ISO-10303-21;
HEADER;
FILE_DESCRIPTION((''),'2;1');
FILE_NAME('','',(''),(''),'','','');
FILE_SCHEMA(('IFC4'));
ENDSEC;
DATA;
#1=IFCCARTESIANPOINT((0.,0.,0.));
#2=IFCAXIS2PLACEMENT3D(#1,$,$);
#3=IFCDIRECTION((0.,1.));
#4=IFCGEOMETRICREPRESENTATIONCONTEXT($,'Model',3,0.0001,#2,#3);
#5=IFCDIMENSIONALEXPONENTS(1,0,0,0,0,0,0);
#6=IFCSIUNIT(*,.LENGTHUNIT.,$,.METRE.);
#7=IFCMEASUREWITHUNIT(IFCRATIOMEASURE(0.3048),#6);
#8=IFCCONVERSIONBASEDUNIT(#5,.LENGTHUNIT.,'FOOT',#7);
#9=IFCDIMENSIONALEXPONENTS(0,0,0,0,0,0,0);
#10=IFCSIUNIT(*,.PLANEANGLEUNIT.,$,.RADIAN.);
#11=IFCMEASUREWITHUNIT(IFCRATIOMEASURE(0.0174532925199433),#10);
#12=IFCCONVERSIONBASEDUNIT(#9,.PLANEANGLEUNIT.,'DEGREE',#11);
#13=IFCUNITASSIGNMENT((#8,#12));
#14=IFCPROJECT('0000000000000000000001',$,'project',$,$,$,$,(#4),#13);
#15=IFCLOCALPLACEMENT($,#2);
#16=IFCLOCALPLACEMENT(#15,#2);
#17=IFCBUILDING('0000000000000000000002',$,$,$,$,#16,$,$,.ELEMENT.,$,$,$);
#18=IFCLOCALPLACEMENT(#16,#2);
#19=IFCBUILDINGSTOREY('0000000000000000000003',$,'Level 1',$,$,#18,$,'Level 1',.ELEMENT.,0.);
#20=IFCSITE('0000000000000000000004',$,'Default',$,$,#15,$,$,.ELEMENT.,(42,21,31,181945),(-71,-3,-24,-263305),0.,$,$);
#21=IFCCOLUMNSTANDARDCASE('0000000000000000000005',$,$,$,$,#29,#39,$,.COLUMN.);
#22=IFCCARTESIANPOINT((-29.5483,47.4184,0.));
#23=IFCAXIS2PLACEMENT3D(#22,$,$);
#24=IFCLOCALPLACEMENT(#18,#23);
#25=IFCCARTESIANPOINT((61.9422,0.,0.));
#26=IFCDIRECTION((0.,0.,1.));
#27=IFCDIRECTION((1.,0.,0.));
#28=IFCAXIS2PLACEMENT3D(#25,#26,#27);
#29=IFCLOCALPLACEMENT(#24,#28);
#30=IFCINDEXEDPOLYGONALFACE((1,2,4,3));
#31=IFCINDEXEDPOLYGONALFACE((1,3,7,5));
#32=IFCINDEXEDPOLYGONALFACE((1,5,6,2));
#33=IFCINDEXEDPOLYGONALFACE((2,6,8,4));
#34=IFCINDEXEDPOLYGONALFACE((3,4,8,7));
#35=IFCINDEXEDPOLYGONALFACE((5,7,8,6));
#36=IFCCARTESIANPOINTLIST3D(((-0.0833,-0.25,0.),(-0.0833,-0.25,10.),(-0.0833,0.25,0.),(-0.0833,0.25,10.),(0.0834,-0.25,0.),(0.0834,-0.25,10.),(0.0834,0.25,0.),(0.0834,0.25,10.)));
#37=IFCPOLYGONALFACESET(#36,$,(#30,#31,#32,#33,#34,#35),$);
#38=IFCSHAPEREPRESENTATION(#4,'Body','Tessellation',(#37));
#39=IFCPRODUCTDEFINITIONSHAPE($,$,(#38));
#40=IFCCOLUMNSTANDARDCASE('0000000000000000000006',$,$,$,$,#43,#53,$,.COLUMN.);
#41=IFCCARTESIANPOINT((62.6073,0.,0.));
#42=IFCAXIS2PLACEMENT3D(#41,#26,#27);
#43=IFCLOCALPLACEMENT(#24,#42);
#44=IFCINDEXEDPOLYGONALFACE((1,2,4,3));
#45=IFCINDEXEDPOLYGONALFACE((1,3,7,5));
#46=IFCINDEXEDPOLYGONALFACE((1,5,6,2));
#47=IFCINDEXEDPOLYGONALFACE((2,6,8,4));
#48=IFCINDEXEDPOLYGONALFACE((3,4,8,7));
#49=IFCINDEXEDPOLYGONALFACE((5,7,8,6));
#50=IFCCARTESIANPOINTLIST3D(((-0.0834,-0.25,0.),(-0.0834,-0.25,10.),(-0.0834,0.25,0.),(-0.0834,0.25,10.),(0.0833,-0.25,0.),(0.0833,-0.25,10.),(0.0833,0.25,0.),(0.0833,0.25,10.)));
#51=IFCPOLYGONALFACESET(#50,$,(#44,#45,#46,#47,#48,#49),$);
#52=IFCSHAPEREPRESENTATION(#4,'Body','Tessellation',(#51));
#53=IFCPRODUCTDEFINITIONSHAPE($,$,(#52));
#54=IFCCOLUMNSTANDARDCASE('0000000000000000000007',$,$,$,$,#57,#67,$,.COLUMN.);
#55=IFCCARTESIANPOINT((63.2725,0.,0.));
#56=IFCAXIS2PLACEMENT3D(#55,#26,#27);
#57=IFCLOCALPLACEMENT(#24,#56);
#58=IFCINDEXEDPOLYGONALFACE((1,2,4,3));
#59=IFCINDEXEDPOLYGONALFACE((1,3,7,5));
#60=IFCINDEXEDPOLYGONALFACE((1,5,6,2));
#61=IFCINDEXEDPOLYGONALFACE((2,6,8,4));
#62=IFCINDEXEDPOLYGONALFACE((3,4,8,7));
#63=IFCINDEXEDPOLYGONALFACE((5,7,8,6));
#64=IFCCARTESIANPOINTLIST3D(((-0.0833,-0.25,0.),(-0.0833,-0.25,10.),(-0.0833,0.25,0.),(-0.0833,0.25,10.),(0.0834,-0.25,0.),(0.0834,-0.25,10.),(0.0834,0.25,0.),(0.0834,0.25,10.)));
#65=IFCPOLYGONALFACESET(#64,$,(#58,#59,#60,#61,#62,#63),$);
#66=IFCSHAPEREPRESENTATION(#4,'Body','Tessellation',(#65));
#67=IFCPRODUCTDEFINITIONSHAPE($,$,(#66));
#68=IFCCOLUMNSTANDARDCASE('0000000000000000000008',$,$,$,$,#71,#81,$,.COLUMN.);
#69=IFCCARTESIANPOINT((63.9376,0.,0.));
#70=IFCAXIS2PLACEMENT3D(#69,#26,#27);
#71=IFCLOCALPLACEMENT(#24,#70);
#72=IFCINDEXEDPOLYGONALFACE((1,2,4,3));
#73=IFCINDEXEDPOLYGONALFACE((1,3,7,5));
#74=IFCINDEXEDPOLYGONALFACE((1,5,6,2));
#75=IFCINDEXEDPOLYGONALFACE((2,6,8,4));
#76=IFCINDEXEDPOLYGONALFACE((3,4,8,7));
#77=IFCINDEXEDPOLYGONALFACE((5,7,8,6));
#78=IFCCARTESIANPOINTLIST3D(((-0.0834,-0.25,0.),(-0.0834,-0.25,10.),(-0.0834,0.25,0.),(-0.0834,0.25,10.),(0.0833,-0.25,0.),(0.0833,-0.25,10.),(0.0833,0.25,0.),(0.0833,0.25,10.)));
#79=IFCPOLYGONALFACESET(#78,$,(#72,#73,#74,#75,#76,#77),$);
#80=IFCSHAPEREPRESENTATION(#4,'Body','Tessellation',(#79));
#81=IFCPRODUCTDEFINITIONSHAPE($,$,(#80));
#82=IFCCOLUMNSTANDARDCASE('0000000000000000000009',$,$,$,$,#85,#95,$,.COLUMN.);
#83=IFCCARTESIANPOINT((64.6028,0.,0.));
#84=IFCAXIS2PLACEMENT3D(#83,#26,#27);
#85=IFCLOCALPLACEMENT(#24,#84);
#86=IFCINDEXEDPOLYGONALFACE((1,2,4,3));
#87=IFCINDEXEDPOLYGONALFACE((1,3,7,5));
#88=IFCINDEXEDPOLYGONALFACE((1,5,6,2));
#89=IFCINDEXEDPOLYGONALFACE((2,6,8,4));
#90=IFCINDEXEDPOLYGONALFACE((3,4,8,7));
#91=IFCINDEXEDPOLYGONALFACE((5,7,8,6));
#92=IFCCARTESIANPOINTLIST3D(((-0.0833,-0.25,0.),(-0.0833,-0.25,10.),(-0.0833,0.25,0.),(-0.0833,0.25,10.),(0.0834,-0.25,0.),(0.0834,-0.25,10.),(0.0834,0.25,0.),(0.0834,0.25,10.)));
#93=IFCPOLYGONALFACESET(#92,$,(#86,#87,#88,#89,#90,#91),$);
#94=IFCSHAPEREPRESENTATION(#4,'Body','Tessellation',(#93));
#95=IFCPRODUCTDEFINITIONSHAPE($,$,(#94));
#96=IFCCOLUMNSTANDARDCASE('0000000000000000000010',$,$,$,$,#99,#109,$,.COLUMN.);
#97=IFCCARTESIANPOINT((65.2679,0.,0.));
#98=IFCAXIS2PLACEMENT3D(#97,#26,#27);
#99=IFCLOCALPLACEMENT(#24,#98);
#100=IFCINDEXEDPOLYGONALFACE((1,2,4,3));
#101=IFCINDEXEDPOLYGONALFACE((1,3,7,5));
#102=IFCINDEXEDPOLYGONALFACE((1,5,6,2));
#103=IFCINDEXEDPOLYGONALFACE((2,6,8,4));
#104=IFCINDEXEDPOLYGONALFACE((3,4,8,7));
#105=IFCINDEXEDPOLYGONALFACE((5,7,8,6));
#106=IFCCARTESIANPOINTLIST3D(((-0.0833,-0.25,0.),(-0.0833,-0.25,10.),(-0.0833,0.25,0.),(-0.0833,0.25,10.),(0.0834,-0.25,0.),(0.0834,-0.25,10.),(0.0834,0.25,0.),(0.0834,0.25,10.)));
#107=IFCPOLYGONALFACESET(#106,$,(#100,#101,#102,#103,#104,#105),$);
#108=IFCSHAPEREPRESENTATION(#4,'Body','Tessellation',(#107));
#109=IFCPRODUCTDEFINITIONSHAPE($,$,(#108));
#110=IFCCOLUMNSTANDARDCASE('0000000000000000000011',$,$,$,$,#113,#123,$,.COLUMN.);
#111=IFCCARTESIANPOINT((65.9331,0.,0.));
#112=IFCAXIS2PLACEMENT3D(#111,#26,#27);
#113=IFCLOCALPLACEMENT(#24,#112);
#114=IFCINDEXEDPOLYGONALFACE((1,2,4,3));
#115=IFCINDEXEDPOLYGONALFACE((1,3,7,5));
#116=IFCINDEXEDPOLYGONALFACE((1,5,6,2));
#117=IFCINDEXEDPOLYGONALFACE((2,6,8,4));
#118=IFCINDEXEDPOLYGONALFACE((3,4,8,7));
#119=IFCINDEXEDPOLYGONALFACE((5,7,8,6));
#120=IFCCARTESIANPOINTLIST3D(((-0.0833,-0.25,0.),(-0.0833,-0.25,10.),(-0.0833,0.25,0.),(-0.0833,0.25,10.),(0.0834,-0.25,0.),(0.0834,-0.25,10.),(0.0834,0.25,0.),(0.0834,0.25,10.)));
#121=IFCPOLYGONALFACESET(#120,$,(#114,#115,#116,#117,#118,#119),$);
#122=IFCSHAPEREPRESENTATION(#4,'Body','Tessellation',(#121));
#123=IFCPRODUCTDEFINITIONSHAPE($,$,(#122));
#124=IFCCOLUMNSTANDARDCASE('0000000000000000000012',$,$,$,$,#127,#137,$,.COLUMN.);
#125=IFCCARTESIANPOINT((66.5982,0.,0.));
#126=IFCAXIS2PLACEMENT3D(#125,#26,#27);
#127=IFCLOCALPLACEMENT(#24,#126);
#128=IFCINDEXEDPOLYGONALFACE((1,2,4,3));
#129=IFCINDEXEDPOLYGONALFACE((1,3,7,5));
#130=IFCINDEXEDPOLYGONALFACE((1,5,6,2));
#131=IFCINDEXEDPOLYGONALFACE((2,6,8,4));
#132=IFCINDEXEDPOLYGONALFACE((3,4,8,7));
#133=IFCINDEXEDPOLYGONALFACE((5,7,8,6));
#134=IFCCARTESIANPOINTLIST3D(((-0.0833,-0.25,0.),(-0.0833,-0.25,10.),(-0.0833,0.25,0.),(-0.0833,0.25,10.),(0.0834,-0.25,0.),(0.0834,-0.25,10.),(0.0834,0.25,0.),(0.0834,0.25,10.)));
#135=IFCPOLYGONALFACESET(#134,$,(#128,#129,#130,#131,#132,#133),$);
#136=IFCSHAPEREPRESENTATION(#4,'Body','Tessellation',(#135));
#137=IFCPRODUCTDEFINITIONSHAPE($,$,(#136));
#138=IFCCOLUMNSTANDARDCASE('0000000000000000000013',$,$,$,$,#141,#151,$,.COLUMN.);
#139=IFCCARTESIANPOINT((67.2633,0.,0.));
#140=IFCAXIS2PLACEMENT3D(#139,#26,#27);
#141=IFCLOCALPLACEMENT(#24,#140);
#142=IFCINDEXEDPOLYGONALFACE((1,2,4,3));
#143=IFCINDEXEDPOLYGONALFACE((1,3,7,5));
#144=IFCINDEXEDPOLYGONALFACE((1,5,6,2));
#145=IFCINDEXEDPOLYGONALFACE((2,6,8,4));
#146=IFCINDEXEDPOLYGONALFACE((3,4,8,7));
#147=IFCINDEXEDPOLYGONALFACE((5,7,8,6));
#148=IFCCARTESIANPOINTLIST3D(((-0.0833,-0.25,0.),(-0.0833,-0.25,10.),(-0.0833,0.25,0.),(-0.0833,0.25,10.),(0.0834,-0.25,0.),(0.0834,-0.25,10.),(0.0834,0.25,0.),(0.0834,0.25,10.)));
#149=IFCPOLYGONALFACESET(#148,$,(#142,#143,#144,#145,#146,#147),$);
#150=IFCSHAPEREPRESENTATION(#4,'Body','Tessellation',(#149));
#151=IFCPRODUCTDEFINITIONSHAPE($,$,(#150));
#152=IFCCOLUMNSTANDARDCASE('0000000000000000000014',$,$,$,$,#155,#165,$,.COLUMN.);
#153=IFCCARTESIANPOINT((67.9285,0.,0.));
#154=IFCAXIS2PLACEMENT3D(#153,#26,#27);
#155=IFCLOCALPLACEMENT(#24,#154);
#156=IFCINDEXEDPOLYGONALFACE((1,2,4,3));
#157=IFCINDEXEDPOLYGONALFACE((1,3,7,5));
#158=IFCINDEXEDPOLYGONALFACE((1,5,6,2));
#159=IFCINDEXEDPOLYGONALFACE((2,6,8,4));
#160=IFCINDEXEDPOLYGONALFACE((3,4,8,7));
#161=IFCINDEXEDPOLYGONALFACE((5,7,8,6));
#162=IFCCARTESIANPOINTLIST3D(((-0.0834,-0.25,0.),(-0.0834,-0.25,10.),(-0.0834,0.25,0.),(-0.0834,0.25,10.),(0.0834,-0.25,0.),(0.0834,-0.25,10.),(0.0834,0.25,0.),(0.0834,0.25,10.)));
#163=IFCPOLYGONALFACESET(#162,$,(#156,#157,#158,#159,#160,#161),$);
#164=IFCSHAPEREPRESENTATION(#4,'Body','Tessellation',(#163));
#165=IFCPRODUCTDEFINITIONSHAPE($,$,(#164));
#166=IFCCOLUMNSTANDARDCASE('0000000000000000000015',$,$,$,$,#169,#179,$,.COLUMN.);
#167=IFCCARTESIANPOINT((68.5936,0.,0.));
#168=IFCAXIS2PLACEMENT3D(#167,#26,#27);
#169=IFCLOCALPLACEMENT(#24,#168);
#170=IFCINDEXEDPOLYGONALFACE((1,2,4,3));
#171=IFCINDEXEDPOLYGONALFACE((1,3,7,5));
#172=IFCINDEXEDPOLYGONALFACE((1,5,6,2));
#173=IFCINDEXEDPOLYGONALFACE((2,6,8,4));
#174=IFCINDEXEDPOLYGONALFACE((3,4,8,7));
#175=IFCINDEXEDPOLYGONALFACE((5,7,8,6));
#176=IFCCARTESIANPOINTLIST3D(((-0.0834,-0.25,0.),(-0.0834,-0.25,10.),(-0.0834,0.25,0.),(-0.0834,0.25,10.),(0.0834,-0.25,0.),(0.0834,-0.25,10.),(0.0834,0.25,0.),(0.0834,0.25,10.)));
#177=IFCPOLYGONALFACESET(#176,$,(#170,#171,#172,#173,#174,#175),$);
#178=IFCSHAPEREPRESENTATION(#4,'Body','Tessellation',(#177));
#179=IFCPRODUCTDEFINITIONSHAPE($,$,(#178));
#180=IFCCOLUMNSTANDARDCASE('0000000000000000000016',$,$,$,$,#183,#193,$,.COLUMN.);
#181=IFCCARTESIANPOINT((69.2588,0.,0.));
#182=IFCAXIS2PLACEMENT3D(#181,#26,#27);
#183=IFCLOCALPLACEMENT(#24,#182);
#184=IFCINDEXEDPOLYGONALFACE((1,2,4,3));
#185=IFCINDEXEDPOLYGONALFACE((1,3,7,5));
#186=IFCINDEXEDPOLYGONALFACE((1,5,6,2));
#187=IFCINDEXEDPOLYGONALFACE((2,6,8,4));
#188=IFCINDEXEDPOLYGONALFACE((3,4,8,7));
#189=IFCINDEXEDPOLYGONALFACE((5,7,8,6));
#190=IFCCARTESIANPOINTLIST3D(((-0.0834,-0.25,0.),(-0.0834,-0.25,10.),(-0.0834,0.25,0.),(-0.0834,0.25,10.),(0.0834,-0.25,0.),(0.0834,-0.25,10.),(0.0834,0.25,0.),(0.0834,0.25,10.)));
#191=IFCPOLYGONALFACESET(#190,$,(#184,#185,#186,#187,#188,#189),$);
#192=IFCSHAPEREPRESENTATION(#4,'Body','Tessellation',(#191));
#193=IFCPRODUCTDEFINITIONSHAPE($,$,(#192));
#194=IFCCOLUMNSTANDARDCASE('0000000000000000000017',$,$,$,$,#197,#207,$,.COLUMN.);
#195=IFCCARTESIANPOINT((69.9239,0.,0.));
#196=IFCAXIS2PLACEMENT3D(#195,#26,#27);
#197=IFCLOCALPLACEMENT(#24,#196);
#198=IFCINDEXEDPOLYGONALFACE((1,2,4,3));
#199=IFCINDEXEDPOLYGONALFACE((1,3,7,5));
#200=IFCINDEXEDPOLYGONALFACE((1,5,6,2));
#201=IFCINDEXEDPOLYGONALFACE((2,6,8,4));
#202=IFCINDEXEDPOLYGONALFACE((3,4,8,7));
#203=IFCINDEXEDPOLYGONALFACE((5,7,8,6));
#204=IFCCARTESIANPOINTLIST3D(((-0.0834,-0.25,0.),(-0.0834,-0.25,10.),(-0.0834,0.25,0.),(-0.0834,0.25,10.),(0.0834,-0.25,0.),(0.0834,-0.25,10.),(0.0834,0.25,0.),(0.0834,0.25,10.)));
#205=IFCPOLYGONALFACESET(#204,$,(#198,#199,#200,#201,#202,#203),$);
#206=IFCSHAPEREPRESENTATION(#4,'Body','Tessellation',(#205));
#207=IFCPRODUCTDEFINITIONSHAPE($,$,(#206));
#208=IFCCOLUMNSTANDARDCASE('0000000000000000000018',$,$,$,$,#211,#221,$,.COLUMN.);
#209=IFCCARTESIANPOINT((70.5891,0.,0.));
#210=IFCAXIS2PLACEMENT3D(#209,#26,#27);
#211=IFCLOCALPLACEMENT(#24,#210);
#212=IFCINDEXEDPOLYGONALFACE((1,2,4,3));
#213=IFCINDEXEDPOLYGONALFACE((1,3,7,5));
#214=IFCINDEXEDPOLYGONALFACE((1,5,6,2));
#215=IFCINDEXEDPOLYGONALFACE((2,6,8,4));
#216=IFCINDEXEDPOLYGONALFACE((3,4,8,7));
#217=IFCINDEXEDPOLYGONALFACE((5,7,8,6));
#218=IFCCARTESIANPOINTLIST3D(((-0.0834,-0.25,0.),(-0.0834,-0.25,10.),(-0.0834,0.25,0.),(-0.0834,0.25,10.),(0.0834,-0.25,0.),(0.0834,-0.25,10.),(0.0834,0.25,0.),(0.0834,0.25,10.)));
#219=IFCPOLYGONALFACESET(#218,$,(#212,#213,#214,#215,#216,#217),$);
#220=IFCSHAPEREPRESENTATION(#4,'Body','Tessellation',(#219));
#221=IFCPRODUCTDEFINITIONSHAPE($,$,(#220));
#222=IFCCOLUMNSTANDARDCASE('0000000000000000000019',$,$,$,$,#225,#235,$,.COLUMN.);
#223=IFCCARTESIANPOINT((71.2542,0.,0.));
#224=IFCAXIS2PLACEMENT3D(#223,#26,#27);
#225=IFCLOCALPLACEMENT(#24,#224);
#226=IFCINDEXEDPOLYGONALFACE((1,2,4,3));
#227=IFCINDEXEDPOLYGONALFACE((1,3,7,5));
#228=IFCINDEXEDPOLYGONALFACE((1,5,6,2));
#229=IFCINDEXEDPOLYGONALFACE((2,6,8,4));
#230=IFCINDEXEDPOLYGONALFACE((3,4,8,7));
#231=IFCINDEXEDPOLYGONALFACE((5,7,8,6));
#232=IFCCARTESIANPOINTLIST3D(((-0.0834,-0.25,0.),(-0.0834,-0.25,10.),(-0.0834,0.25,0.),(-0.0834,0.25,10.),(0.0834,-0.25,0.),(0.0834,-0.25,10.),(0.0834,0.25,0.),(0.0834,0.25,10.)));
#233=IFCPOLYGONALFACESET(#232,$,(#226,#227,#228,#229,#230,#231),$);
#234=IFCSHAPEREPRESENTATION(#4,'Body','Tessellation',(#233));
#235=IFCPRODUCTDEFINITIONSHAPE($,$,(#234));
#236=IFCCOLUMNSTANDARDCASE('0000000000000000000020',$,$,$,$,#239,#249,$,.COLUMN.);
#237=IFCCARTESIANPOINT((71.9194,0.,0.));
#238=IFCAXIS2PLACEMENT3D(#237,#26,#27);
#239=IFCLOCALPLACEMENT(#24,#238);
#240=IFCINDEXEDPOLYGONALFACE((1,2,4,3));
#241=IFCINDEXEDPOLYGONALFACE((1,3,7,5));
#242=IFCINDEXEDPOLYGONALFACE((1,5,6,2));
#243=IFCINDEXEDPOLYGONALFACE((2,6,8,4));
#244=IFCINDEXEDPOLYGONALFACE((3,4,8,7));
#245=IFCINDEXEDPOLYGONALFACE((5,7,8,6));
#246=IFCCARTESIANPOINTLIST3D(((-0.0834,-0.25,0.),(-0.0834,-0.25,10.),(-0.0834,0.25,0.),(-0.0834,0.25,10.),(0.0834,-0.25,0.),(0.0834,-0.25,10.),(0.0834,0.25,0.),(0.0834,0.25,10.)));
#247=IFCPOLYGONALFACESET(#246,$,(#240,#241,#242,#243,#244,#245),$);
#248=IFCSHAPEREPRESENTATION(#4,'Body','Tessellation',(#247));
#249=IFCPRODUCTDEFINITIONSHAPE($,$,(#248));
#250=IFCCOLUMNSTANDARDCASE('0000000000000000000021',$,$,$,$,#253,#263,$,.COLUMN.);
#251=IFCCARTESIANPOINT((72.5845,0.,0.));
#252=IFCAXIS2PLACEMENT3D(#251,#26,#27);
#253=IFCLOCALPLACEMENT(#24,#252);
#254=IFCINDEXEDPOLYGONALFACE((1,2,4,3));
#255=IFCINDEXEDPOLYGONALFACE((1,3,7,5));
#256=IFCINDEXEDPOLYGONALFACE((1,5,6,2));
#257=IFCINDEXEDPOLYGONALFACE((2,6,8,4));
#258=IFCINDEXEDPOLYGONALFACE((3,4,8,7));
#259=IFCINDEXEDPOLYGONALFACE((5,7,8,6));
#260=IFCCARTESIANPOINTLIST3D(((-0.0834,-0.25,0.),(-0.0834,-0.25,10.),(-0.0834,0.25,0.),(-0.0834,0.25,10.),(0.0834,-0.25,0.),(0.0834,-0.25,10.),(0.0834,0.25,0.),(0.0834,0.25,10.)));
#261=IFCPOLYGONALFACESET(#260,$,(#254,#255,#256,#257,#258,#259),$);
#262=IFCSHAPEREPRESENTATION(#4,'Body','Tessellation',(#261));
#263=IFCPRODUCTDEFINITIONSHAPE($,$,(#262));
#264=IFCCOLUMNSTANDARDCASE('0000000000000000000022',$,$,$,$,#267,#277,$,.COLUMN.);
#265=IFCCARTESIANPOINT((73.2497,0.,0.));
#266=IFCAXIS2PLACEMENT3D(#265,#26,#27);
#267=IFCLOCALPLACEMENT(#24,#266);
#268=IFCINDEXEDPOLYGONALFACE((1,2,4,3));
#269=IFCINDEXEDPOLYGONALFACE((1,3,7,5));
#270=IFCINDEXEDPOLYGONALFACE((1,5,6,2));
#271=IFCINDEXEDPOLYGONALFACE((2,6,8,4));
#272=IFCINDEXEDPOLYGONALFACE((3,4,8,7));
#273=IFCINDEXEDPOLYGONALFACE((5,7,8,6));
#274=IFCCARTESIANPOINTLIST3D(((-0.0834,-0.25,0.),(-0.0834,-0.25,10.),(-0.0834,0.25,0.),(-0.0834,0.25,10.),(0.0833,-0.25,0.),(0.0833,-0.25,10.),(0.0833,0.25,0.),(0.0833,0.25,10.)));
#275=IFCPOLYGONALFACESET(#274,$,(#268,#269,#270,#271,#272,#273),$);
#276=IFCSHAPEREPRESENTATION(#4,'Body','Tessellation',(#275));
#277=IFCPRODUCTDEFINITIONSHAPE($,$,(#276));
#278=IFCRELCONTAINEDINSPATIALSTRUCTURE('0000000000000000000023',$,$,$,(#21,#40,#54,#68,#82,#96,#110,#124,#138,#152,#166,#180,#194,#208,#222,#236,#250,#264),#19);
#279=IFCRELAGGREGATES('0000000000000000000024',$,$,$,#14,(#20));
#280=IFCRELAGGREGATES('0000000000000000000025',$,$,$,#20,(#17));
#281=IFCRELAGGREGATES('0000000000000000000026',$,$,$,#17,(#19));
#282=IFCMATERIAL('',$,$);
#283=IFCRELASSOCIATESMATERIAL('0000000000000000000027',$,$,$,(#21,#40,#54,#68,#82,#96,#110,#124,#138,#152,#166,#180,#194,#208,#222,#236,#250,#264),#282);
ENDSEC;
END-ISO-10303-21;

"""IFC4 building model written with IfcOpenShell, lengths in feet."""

from ifc_helpers import new_model, entity, si_unit, converted_unit, direction, frame, origin, place, context, project, spatial, rectangle, extrude, material, element, save


model = new_model("IFC4")

# Units and contexts
model_context = context("Model", 3, precision=0.0001, world=origin(), true_north=direction((0.0, 1.0)))
ifc_project = project(units=[converted_unit("LENGTHUNIT", "FOOT", entity("IfcRatioMeasure", 0.3048), si_unit("LENGTHUNIT", "METRE"), dimensions=[1, 0, 0, 0, 0, 0, 0]), converted_unit("PLANEANGLEUNIT", "DEGREE", entity("IfcRatioMeasure", 0.0174532925199433), si_unit("PLANEANGLEUNIT", "RADIAN"), dimensions=[0, 0, 0, 0, 0, 0, 0])], contexts=[model_context])

# Site, building, storey
site_placement = place(None, origin())
site = spatial("IfcSite", under=ifc_project, at=site_placement, Name="Default", CompositionType="ELEMENT", RefLatitude=(42, 21, 31, 181945), RefLongitude=(-71, -3, -24, -263305), RefElevation=0.0)
building_placement = place(site_placement, origin())
building = spatial("IfcBuilding", under=site, at=building_placement, CompositionType="ELEMENT")
storey_placement = place(building_placement, origin())
storey = spatial("IfcBuildingStorey", under=building, at=storey_placement, Name="Level 1", LongName="Level 1", CompositionType="ELEMENT", Elevation=0.0)

# Columns
ifc_material_1 = material(Name="")
placement = place(storey_placement, frame((-29.5483, 47.4184, 0.0)))
for number, where, z_axis, x_axis in (
    (1, (61.9422, 0.0, 0.0), (0.0, 0.0, 1.0), (1.0, 0.0, 0.0)),
    (2, (62.6073, 0.0, 0.0), (0.0, 0.0, 1.0), (1.0, 0.0, 0.0)),
    (3, (63.2725, 0.0, 0.0), (0.0, 0.0, 1.0), (1.0, 0.0, 0.0)),
    (4, (63.9376, 0.0, 0.0), (0.0, 0.0, 1.0), (1.0, 0.0, 0.0)),
    (5, (64.6028, 0.0, 0.0), (0.0, 0.0, 1.0), (1.0, 0.0, 0.0)),
    (6, (65.2679, 0.0, 0.0), (0.0, 0.0, 1.0), (1.0, 0.0, 0.0)),
    (7, (65.9331, 0.0, 0.0), (0.0, 0.0, 1.0), (1.0, 0.0, 0.0)),
    (8, (66.5982, 0.0, 0.0), (0.0, 0.0, 1.0), (1.0, 0.0, 0.0)),
    (9, (67.2633, 0.0, 0.0), (0.0, 0.0, 1.0), (1.0, 0.0, 0.0)),
    (10, (67.9285, 0.0, 0.0), (0.0, 0.0, 1.0), (1.0, 0.0, 0.0)),
    (11, (68.5936, 0.0, 0.0), (0.0, 0.0, 1.0), (1.0, 0.0, 0.0)),
    (12, (69.2588, 0.0, 0.0), (0.0, 0.0, 1.0), (1.0, 0.0, 0.0)),
    (13, (69.9239, 0.0, 0.0), (0.0, 0.0, 1.0), (1.0, 0.0, 0.0)),
    (14, (70.5891, 0.0, 0.0), (0.0, 0.0, 1.0), (1.0, 0.0, 0.0)),
    (15, (71.2542, 0.0, 0.0), (0.0, 0.0, 1.0), (1.0, 0.0, 0.0)),
    (16, (71.9194, 0.0, 0.0), (0.0, 0.0, 1.0), (1.0, 0.0, 0.0)),
    (17, (72.5845, 0.0, 0.0), (0.0, 0.0, 1.0), (1.0, 0.0, 0.0)),
    (18, (73.2497, 0.0, 0.0), (0.0, 0.0, 1.0), (1.0, 0.0, 0.0)),
):
    element("IfcColumnStandardCase", number, at=place(placement, frame(where, z_axis=z_axis, x_axis=x_axis)), inside=storey, material=ifc_material_1, PredefinedType="COLUMN", context=model_context, shape_type="SweptSolid", body=[
        extrude(rectangle(XDim=0.1667, YDim=0.5), origin(), (0.0, 0.0, 1.0), 10.0),
    ])

save(model, "model.ifc")
